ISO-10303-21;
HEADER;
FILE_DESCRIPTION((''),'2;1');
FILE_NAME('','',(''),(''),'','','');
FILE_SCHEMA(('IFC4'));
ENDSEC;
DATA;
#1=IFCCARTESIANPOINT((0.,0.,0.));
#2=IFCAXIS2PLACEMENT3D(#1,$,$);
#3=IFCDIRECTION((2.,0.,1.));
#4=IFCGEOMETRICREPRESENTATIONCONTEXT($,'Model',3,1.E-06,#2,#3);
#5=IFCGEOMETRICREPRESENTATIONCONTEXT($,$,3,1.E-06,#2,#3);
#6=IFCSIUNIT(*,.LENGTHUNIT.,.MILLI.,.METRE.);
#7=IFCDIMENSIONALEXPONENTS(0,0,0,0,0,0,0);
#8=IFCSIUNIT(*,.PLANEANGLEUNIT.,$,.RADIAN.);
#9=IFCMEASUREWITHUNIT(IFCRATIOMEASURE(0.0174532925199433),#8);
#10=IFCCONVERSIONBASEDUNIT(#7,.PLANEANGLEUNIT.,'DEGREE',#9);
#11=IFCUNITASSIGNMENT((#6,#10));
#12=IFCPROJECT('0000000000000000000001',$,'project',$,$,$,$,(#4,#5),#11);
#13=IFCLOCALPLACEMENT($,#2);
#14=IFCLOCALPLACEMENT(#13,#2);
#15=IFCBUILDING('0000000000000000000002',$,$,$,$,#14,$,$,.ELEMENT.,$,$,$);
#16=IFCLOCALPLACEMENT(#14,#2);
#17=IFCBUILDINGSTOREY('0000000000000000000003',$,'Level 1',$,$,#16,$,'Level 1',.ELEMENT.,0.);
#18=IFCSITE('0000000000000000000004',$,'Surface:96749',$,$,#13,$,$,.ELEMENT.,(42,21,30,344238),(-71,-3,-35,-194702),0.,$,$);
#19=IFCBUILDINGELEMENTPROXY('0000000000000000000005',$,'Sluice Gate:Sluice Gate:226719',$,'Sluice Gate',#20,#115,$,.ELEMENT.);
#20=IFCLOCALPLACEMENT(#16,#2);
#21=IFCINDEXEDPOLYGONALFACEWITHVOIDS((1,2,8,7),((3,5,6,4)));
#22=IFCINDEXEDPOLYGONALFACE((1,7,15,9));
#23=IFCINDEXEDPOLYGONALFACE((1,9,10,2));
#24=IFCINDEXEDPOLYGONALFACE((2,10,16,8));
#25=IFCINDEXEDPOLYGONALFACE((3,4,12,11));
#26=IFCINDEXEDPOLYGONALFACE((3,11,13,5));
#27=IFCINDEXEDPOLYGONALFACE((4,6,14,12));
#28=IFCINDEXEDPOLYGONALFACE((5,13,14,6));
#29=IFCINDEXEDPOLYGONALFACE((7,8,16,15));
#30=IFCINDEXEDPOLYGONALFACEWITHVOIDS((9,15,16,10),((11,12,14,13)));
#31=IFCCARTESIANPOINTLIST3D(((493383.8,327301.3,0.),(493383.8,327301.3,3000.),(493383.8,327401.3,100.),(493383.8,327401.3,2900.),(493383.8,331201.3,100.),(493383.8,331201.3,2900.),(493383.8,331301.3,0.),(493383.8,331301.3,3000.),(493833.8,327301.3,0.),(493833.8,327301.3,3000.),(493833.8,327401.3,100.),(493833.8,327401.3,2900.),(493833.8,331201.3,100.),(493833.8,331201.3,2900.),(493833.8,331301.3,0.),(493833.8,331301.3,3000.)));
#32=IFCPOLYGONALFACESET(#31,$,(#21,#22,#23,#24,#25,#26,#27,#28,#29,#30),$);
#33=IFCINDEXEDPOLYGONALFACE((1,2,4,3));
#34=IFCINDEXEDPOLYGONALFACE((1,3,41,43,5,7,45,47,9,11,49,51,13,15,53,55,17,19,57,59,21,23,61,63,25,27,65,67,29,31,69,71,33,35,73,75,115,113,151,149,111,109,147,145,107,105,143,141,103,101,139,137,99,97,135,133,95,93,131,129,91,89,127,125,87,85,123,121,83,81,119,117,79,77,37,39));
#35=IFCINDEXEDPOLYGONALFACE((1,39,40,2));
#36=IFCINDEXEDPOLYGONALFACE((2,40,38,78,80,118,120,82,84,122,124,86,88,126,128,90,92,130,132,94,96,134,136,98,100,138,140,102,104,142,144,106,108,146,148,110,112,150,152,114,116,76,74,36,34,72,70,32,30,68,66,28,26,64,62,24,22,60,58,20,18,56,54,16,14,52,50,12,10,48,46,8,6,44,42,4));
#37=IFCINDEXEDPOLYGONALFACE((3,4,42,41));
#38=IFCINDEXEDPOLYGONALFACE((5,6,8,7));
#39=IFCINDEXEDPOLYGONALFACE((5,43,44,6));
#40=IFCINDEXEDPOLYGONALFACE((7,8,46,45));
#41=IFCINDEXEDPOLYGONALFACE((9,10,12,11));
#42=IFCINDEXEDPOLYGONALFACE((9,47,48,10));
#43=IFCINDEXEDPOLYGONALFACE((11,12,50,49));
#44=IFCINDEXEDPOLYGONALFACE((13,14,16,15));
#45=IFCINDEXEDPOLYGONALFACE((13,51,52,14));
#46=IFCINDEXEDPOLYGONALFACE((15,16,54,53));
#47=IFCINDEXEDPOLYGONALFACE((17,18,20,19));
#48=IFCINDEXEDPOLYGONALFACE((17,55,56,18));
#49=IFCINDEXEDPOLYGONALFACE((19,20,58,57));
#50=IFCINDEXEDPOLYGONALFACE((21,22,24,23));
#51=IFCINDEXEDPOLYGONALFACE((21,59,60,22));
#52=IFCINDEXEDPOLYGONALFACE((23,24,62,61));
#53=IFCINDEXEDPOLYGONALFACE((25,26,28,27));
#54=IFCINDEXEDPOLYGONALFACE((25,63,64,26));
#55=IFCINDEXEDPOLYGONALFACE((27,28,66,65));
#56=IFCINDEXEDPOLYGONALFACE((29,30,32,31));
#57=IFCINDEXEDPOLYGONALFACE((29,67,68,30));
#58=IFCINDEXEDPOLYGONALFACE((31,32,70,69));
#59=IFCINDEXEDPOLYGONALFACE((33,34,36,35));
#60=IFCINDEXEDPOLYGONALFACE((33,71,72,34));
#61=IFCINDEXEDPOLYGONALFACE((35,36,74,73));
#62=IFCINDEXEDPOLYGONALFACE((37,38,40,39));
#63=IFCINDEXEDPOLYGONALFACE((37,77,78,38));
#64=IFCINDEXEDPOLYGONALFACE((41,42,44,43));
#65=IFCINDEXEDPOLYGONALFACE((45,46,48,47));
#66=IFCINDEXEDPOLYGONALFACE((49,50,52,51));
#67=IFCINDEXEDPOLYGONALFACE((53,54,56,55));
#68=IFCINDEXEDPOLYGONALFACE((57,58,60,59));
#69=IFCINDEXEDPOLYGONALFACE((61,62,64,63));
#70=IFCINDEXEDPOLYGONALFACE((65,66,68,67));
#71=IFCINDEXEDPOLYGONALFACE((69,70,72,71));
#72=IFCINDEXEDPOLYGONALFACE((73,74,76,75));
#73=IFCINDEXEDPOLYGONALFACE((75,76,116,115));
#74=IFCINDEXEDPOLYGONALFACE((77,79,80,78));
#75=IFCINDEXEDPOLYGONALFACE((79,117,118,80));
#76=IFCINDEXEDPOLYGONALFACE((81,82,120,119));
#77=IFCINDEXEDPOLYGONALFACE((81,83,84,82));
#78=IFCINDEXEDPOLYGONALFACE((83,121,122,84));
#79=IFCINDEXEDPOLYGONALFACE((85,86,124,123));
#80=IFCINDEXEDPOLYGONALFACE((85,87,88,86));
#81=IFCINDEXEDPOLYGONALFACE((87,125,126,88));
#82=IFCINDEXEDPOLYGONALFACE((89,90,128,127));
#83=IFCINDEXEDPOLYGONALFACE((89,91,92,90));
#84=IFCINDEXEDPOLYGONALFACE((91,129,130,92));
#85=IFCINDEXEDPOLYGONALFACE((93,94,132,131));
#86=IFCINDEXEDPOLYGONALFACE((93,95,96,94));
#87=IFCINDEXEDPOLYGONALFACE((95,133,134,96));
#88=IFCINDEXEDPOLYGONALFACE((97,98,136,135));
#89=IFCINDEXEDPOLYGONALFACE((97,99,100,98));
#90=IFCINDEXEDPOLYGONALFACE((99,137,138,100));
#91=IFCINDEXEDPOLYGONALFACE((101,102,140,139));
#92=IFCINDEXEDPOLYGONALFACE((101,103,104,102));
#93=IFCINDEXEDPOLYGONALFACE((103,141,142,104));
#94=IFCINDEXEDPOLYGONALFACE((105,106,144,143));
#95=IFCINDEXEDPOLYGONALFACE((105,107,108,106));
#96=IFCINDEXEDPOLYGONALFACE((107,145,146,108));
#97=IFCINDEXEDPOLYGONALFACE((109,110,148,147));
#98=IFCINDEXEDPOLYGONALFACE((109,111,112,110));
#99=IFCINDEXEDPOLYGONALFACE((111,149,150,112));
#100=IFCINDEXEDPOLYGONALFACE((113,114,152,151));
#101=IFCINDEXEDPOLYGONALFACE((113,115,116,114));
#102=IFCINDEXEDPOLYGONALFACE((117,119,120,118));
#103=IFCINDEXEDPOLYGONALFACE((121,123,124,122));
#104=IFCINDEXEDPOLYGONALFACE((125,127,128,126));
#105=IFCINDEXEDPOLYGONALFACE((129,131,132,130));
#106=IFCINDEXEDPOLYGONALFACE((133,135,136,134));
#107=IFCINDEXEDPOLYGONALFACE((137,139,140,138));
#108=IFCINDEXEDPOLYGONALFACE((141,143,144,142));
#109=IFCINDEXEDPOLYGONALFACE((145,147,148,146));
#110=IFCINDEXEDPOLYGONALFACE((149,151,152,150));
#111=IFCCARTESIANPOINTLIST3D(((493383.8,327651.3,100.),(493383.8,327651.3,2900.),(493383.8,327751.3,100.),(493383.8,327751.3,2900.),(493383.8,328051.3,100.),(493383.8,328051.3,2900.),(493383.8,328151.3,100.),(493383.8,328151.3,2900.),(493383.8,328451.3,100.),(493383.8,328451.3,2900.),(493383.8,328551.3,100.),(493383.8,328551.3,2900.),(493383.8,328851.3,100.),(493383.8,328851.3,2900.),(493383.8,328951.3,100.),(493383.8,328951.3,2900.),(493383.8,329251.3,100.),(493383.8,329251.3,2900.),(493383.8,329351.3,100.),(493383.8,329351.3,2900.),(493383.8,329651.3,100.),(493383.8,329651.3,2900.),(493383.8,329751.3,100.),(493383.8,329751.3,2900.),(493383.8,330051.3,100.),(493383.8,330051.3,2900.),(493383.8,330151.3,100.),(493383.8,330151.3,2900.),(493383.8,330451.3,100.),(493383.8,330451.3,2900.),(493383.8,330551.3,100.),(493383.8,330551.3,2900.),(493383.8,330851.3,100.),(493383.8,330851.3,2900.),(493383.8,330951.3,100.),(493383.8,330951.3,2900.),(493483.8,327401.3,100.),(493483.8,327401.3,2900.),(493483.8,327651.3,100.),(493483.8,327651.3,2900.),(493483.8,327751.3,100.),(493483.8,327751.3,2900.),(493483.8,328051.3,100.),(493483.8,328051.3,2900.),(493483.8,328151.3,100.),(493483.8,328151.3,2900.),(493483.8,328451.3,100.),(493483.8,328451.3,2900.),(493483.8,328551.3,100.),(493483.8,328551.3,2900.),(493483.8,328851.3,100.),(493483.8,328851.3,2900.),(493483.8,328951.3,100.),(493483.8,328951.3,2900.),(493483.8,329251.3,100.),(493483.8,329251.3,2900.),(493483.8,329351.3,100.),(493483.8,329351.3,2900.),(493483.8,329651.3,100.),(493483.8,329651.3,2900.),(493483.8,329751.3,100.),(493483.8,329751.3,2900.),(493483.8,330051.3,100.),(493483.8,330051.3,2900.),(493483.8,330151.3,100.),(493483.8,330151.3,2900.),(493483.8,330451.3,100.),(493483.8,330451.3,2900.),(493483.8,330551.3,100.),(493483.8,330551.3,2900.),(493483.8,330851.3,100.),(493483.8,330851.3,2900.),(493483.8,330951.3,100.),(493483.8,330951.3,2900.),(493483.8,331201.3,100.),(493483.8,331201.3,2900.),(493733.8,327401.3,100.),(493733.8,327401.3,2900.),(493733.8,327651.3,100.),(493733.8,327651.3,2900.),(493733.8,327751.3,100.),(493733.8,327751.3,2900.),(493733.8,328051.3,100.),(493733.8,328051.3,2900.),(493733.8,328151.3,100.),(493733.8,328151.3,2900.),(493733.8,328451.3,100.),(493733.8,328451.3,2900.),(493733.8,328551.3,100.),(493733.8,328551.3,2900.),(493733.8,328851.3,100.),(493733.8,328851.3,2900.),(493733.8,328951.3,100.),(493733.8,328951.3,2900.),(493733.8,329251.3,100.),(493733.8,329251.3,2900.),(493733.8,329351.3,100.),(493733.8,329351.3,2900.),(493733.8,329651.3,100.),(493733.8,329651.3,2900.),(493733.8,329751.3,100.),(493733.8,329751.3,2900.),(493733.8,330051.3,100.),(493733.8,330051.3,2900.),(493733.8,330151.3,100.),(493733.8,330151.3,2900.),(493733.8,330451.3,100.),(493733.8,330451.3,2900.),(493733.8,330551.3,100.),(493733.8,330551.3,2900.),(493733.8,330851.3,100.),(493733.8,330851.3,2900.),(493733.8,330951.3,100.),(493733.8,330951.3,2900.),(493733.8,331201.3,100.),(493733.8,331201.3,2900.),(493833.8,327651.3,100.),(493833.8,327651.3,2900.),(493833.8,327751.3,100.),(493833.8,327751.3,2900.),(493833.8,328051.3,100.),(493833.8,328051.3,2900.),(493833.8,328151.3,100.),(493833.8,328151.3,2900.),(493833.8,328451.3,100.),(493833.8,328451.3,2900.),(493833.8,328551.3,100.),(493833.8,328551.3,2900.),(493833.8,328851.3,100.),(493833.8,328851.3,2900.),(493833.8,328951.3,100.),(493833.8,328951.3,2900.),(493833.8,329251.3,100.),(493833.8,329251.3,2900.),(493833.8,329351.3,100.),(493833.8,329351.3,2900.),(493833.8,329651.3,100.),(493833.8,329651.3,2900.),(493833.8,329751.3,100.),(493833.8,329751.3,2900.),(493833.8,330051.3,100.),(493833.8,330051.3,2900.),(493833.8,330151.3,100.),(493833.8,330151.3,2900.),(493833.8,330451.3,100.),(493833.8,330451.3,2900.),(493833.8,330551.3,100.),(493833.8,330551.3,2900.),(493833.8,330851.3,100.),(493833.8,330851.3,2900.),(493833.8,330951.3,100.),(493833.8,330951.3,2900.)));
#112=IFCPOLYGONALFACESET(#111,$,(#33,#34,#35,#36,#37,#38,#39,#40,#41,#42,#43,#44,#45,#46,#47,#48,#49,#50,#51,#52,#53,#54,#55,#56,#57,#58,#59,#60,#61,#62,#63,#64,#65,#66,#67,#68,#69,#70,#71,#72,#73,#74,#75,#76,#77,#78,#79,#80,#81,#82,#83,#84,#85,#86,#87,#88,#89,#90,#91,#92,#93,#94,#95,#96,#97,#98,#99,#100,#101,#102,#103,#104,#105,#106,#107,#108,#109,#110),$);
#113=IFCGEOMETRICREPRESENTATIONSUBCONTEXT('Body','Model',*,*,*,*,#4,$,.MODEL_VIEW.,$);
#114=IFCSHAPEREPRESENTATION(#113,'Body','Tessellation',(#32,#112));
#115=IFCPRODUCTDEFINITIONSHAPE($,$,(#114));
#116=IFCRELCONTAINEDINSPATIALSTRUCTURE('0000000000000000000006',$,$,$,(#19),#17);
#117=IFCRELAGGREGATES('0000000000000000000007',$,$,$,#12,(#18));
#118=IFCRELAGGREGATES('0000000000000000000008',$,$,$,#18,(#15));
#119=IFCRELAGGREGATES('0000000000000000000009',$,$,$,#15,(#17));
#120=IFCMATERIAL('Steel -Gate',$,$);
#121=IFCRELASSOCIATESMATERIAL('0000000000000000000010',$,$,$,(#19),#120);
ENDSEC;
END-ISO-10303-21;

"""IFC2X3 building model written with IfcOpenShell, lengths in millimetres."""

from ifc_helpers import new_model, entity, si_unit, converted_unit, direction, frame, origin, place, context, subcontext, project, spatial, polyline, outline, extrude, source, transform, mapped, material, element, save


model = new_model("IFC2X3")

# Units and contexts
model_context = context("Model", 3, precision=1e-06, world=origin(), true_north=direction((2.0, 0.0, 1.0)))
context_of_model = context(None, 3, precision=1e-06, world=origin(), true_north=direction((2.0, 0.0, 1.0)))
body_context = subcontext(model_context, "Body", "Model", "MODEL_VIEW")
ifc_project = project(units=[si_unit("LENGTHUNIT", "METRE", prefix="MILLI"), converted_unit("PLANEANGLEUNIT", "DEGREE", entity("IfcRatioMeasure", 0.0174532925199433), si_unit("PLANEANGLEUNIT", "RADIAN"), dimensions=[0, 0, 0, 0, 0, 0, 0])], contexts=[model_context, context_of_model])

# Site, building, storey
site_placement = place(None, origin())
site = spatial("IfcSite", under=ifc_project, at=site_placement, Name="Surface:96749", CompositionType="ELEMENT", RefLatitude=(42, 21, 30, 344238), RefLongitude=(-71, -3, -35, -194702), RefElevation=0.0)
building_placement = place(site_placement, origin())
building = spatial("IfcBuilding", under=site, at=building_placement, CompositionType="ELEMENT")
storey_placement = place(building_placement, origin())
storey = spatial("IfcBuildingStorey", under=building, at=storey_placement, Name="Level 1", LongName="Level 1", CompositionType="ELEMENT", Elevation=0.0)

# Building element proxy
ifc_material = material(Name="Steel -Gate")
shared_shape_1 = source(origin(), body_context, "Body", "SweptSolid", [
    extrude(outline(polyline([(-2000.0, -1500.0), (2000.0, -1500.0), (2000.0, 1500.0), (-2000.0, 1500.0), (-2000.0, -1500.0)]), holes=[polyline([(-1900.0, 1400.0), (1900.0, 1400.0), (1900.0, -1400.0), (-1900.0, -1400.0), (-1900.0, 1400.0)])]), frame((0.0, -225.0, 1500.0), z_axis=(0.0, 1.0, 0.0), x_axis=(-1.0, 0.0, 0.0)), (0.0, 0.0, 1.0), 450.0),
    extrude(outline(polyline([(125.0, -1650.0), (225.0, -1650.0), (225.0, -1550.0), (125.0, -1550.0), (125.0, -1250.0), (225.0, -1250.0), (225.0, -1150.0), (125.0, -1150.0), (125.0, -850.0), (225.0, -850.0), (225.0, -750.0), (125.0, -750.0), (125.0, -450.0), (225.0, -450.0), (225.0, -350.0), (125.0, -350.0), (125.0, -50.0), (225.0, -50.0), (225.0, 50.0), (125.0, 50.0), (125.0, 350.0), (225.0, 350.0), (225.0, 450.0), (125.0, 450.0), (125.0, 750.0), (225.0, 750.0), (225.0, 850.0), (125.0, 850.0), (125.0, 1150.0), (225.0, 1150.0), (225.0, 1250.0), (125.0, 1250.0), (125.0, 1550.0), (225.0, 1550.0), (225.0, 1650.0), (125.0, 1650.0), (125.0, 1900.0), (-125.0, 1900.0), (-125.0, 1650.0), (-225.0, 1650.0), (-225.0, 1550.0), (-125.0, 1550.0), (-125.0, 1250.0), (-225.0, 1250.0), (-225.0, 1150.0), (-125.0, 1150.0), (-125.0, 850.0), (-225.0, 850.0), (-225.0, 750.0), (-125.0, 750.0), (-125.0, 450.0), (-225.0, 450.0), (-225.0, 350.0), (-125.0, 350.0), (-125.0, 50.0), (-225.0, 50.0), (-225.0, -50.0), (-125.0, -50.0), (-125.0, -350.0), (-225.0, -350.0), (-225.0, -450.0), (-125.0, -450.0), (-125.0, -750.0), (-225.0, -750.0), (-225.0, -850.0), (-125.0, -850.0), (-125.0, -1150.0), (-225.0, -1150.0), (-225.0, -1250.0), (-125.0, -1250.0), (-125.0, -1550.0), (-225.0, -1550.0), (-225.0, -1650.0), (-125.0, -1650.0), (-125.0, -1900.0), (125.0, -1900.0), (125.0, -1650.0)])), frame((0.0, 0.0, 100.0), z_axis=(0.0, 0.0, 1.0), x_axis=(0.0, -1.0, 0.0)), (0.0, 0.0, 1.0), 2800.0),
])
for number, where, z_axis, x_axis, name in (
    (1, (493608.8, 329301.3, 0.0), (0.0, 0.0, 1.0), (0.0, 1.0, 0.0), "Sluice Gate:Sluice Gate:226719"),
):
    element("IfcBuildingElementProxy", number, at=place(storey_placement, frame(where, z_axis=z_axis, x_axis=x_axis)), inside=storey, material=ifc_material, Name=name, ObjectType="Sluice Gate", CompositionType="ELEMENT", context=body_context, shape_type="MappedRepresentation", body=[
        mapped(shared_shape_1, transform((0.0, 0.0, 0.0), scale=1.0)),
    ])

save(model, "model.ifc")
